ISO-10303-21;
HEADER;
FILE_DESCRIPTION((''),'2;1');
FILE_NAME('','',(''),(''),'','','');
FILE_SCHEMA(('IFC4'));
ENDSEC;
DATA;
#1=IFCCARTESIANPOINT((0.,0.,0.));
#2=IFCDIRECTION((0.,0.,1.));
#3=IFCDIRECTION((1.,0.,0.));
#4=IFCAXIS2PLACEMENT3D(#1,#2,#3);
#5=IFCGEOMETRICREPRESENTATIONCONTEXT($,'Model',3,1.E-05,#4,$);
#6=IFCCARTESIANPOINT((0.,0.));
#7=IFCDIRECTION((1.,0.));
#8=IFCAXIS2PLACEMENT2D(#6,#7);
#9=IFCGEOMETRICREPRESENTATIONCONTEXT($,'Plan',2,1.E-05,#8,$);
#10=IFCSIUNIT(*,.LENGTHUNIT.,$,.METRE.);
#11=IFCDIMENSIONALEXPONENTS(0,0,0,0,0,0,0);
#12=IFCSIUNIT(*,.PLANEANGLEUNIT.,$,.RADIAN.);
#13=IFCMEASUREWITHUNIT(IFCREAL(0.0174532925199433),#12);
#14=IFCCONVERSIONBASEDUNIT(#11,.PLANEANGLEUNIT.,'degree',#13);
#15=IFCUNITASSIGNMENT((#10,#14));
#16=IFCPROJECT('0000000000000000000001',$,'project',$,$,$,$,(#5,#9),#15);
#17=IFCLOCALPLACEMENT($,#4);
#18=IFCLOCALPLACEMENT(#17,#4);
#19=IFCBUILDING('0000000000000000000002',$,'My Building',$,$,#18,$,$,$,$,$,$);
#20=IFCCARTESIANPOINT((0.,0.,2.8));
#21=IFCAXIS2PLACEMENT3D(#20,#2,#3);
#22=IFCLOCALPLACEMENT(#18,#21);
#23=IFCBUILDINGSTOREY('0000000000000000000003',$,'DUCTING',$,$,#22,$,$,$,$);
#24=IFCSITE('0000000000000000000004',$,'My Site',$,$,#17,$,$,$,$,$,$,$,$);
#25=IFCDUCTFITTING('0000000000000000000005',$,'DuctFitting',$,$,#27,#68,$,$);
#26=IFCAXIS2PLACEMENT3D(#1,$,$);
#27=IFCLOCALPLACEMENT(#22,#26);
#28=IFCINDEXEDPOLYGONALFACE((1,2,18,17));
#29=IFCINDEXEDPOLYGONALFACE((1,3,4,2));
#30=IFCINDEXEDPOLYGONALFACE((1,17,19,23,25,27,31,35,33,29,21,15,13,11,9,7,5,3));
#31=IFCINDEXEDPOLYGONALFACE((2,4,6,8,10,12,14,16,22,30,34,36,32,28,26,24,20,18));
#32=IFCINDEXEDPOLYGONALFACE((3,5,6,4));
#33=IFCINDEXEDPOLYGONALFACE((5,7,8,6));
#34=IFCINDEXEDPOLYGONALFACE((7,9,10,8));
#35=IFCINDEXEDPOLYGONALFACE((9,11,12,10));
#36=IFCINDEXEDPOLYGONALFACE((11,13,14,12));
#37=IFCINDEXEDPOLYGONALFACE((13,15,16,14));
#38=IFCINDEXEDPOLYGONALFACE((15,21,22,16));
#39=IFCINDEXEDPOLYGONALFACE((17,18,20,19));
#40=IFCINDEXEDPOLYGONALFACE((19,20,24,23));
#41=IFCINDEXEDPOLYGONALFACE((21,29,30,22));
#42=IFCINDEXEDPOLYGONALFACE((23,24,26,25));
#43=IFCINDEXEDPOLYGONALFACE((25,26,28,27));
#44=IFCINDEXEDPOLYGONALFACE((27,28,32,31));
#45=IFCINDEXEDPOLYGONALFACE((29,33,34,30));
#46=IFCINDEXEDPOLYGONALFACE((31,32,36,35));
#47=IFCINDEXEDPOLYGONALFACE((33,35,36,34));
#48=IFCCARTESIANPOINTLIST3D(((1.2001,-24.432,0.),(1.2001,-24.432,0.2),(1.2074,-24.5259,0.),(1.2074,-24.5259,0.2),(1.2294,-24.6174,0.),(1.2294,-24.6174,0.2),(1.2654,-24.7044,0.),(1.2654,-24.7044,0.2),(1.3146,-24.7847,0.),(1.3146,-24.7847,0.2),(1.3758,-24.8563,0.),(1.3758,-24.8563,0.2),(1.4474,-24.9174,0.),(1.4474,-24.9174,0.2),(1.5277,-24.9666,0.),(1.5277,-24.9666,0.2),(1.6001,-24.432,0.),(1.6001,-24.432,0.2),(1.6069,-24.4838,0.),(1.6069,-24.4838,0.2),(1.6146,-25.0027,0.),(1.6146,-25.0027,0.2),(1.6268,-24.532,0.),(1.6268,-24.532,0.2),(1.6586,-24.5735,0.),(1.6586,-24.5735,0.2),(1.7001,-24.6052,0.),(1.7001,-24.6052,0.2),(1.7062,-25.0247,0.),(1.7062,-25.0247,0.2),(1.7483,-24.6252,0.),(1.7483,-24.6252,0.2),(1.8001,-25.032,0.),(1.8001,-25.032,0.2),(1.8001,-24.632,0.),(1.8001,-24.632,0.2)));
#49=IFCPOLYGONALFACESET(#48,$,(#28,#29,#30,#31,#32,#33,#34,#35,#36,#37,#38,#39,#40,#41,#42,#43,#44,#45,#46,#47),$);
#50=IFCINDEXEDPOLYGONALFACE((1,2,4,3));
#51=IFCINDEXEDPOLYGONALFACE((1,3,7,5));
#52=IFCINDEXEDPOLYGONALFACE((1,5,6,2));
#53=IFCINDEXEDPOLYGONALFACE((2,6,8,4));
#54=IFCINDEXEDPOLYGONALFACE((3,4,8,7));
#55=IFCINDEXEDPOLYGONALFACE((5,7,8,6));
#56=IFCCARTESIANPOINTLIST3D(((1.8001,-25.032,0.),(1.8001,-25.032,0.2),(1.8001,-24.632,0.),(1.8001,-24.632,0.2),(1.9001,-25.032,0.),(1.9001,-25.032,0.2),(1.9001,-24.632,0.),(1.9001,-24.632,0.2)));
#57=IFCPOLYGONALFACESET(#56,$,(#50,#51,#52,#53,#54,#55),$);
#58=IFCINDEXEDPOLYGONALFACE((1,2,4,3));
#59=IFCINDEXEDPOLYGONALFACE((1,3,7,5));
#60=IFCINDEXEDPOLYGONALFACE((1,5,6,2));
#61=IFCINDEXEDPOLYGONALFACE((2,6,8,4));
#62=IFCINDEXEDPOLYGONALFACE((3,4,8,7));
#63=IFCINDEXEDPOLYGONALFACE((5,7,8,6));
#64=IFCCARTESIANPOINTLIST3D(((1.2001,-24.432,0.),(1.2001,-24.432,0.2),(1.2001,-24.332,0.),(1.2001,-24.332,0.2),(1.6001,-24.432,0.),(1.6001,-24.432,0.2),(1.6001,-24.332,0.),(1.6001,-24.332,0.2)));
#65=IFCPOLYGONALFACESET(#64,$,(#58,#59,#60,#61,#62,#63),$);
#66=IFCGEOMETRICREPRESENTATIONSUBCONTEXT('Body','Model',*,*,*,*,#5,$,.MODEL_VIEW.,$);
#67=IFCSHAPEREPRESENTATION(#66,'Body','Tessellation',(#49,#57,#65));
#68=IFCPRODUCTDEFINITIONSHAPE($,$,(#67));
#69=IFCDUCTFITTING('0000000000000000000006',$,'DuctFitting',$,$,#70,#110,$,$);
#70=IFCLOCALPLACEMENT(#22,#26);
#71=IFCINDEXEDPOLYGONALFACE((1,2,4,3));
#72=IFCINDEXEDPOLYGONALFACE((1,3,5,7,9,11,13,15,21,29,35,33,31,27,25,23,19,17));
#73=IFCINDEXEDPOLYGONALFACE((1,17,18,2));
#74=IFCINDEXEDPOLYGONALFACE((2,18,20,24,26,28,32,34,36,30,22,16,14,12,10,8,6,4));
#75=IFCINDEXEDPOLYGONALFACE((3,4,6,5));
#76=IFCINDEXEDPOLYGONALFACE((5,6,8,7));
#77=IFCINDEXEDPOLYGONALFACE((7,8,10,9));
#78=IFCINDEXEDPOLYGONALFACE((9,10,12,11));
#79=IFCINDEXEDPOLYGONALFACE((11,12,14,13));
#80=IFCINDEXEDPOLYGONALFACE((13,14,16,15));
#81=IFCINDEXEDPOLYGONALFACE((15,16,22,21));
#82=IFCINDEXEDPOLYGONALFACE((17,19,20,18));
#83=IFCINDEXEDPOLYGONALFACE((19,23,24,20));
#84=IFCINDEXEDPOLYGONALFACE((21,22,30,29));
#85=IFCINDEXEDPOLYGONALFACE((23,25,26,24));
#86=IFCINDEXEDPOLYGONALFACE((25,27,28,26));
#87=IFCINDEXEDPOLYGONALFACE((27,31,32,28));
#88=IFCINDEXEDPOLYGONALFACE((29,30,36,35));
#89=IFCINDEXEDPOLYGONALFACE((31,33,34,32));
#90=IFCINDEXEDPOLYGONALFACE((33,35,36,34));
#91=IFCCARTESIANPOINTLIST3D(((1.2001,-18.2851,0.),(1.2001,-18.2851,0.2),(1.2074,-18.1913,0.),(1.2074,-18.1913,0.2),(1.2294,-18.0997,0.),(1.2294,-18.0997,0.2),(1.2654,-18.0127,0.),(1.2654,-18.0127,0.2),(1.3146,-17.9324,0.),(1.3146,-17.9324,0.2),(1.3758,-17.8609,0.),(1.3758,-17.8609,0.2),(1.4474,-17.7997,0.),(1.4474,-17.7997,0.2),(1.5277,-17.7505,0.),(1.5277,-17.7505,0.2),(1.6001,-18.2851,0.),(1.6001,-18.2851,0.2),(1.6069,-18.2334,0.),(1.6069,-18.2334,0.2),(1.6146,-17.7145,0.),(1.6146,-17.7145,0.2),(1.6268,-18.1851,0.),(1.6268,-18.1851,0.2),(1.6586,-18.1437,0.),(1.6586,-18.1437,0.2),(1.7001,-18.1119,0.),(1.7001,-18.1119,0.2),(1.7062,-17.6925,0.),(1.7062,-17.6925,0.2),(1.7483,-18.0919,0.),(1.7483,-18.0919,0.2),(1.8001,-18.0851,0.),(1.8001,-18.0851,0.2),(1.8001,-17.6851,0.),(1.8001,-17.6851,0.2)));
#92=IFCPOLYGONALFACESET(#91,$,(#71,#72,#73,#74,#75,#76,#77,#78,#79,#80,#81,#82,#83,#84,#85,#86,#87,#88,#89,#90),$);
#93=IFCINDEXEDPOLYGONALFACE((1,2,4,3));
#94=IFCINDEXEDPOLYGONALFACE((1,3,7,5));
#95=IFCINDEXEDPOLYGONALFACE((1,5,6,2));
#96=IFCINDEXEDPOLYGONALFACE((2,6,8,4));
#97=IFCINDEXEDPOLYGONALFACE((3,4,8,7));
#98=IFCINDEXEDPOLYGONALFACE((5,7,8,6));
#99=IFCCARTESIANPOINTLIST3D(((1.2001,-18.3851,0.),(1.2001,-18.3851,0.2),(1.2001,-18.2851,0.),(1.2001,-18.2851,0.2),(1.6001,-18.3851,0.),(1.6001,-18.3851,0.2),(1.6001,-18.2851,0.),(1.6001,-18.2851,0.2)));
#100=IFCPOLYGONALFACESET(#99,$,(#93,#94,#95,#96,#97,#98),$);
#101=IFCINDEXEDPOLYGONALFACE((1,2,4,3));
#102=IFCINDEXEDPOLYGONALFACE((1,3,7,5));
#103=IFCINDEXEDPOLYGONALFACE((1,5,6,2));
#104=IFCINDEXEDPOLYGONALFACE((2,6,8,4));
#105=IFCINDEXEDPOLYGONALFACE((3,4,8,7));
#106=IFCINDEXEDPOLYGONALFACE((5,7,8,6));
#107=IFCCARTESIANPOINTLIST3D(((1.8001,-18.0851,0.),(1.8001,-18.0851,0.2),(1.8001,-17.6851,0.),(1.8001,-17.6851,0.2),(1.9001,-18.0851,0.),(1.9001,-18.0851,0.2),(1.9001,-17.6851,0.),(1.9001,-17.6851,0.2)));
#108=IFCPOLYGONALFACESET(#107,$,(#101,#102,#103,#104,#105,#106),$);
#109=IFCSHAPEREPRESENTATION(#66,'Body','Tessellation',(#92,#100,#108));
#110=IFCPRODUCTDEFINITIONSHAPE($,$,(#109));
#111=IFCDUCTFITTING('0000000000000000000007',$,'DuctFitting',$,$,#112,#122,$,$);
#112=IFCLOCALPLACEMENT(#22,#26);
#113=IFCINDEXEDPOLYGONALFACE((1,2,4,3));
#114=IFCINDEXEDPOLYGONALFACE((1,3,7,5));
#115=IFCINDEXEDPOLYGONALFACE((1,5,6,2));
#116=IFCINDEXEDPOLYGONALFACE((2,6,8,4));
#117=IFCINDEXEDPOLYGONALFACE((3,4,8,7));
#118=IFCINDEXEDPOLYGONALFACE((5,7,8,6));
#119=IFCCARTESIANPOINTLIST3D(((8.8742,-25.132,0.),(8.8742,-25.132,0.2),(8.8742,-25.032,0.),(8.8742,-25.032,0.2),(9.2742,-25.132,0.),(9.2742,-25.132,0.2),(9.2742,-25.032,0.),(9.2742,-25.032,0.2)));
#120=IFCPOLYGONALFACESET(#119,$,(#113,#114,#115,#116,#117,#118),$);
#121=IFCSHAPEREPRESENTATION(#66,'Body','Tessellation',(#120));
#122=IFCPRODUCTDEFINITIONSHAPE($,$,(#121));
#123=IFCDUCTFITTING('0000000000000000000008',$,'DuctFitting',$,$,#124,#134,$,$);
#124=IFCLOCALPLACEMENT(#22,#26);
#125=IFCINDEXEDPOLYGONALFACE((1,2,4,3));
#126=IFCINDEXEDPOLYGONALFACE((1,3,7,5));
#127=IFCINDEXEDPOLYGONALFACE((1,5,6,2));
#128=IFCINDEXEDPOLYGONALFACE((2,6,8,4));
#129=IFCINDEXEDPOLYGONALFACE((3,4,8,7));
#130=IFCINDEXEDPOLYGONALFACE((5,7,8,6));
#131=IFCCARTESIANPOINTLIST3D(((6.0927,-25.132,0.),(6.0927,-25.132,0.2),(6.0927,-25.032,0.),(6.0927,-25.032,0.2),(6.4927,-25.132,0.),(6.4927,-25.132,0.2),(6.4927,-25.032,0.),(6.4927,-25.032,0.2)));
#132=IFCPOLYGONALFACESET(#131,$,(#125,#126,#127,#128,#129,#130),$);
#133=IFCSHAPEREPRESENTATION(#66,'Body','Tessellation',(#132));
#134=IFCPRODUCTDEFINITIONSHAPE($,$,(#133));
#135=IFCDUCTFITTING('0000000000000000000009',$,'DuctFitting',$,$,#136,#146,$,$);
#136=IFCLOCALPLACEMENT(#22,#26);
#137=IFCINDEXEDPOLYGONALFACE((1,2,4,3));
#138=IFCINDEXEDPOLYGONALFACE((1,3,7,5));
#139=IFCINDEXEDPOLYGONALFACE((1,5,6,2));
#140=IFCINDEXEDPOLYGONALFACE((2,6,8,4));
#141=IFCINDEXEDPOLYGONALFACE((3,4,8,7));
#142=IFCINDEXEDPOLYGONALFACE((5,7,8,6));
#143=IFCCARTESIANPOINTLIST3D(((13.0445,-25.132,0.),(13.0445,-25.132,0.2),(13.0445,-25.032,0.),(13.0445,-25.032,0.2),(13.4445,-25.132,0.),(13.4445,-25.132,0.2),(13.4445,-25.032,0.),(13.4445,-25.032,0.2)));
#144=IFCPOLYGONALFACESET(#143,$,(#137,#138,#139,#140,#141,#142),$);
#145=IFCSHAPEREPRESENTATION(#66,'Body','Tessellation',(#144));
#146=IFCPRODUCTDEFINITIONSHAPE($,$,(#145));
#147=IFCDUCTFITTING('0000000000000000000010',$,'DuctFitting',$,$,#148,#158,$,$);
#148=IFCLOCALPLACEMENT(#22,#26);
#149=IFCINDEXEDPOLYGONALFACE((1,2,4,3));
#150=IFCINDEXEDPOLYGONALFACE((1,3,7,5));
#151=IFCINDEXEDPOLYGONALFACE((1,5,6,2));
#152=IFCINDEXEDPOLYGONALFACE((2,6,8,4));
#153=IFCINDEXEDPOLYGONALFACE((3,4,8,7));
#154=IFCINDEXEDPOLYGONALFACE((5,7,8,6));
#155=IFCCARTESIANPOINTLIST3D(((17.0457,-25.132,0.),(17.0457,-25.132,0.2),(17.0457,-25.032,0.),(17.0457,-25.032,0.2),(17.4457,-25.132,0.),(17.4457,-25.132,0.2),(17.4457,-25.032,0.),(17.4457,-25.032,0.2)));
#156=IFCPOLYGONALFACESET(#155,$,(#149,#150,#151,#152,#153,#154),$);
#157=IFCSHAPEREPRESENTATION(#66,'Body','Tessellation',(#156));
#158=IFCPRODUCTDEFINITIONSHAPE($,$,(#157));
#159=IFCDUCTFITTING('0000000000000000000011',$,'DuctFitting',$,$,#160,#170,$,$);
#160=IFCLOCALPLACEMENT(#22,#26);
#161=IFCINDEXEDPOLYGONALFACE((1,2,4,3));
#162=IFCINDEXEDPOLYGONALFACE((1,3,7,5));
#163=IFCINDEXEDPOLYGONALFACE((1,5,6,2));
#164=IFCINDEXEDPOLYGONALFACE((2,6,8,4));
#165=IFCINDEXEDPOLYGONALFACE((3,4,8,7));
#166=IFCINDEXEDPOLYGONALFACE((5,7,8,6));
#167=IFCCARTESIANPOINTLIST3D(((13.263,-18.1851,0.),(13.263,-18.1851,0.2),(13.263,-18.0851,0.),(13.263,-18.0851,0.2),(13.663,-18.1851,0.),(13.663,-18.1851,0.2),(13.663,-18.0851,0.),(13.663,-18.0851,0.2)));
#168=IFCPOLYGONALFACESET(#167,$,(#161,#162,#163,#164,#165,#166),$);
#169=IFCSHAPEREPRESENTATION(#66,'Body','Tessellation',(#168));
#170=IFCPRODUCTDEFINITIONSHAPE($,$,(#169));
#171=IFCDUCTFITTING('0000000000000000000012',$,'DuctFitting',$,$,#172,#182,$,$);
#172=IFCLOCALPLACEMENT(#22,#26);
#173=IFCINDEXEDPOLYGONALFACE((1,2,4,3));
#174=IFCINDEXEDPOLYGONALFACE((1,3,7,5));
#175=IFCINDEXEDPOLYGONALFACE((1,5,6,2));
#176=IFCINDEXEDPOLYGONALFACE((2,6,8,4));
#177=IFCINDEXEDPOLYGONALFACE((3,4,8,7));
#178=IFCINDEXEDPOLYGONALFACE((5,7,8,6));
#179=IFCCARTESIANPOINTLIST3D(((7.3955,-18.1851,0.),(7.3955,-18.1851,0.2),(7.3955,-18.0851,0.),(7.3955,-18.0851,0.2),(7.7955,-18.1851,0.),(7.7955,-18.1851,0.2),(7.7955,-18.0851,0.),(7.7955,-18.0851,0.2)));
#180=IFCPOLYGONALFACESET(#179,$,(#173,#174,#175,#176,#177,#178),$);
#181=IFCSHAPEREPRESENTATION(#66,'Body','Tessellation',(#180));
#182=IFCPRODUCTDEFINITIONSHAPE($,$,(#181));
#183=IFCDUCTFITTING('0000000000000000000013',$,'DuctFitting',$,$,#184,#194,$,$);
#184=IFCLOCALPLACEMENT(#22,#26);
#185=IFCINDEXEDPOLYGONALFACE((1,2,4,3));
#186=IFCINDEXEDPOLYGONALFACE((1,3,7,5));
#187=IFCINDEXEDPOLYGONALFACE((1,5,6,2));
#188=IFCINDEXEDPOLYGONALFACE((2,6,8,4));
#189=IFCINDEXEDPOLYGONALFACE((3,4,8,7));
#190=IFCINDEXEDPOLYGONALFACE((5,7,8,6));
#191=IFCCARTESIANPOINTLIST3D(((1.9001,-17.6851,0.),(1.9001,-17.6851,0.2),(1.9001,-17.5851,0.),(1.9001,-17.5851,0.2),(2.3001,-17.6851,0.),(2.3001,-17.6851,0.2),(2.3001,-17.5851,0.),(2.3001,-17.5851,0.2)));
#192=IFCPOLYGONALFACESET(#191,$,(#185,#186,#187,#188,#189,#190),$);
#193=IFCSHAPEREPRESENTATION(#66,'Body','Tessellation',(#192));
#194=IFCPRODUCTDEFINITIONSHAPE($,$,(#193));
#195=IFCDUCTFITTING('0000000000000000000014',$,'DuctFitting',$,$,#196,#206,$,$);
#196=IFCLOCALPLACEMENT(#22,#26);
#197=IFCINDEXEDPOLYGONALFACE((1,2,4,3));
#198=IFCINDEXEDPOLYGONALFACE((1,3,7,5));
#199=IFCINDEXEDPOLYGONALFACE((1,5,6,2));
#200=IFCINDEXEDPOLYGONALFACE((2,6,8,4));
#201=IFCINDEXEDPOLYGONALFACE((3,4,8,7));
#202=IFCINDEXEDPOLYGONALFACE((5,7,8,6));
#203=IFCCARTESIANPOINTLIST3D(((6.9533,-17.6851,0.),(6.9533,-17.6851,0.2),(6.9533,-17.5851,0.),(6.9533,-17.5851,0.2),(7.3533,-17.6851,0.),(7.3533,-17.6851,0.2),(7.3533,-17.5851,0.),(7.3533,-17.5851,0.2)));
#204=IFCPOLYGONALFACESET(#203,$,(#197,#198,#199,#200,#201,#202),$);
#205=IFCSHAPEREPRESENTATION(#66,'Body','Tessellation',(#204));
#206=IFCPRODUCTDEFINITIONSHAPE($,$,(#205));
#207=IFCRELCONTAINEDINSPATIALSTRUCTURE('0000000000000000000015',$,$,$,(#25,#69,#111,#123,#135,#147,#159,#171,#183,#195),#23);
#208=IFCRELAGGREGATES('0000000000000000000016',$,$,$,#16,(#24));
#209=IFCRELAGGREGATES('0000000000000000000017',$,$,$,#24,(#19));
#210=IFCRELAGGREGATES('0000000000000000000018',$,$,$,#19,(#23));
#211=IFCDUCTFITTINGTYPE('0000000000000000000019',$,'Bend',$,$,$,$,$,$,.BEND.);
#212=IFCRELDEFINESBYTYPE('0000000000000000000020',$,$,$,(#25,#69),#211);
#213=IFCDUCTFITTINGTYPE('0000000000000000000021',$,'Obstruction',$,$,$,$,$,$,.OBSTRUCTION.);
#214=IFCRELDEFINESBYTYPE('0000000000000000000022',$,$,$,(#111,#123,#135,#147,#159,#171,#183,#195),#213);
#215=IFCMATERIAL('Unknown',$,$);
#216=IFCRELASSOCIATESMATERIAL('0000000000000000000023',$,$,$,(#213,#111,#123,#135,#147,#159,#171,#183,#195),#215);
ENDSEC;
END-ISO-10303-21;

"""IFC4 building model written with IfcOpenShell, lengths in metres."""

from ifc_helpers import new_model, entity, si_unit, converted_unit, frame, origin_with_axes, origin_2d_with_axis, place, context, subcontext, project, spatial, line, arc, indexed_curve, rectangle, outline, extrude, source, transform, mapped, material, material_profile, profile_set, profile_usage, type_object, type_shapes, element, save


model = new_model("IFC4")

# Units and contexts
model_context = context("Model", 3, precision=1e-05, world=origin_with_axes())
plan_context = context("Plan", 2, precision=1e-05, world=origin_2d_with_axis())
body_context = subcontext(model_context, "Body", "Model", "MODEL_VIEW")
ifc_project = project(units=[si_unit("LENGTHUNIT", "METRE"), converted_unit("PLANEANGLEUNIT", "degree", entity("IfcReal", 0.0174532925199433), si_unit("PLANEANGLEUNIT", "RADIAN"), dimensions=[0, 0, 0, 0, 0, 0, 0])], contexts=[model_context, plan_context])

# Site, building, storey
site_placement = place(None, origin_with_axes())
site = spatial("IfcSite", under=ifc_project, at=site_placement, Name="My Site")
building_placement = place(site_placement, origin_with_axes())
building = spatial("IfcBuilding", under=site, at=building_placement, Name="My Building")
storey_placement = place(building_placement, frame((0.0, 0.0, 2.8), z_axis=(0.0, 0.0, 1.0), x_axis=(1.0, 0.0, 0.0)))
storey = spatial("IfcBuildingStorey", under=building, at=storey_placement, Name="DUCTING")

# Shared definitions
ifc_material = material(Name="Unknown")

# Duct fittings
duct_fitting_type_1 = type_object("IfcDuctFittingType", Name="Bend", PredefinedType="BEND")
shared_shape = source(origin_with_axes(), body_context, "Body", "SweptSolid", [
    extrude(outline(indexed_curve([(0.2, 0.0), (0.2586, -0.1414), (0.4, -0.2), (0.4, -0.6), (-0.0243, -0.4243), (-0.2, 0.0)], segments=[arc(1, 2, 3), line(3, 4), arc(4, 5, 6), line(6, 1)])), frame((0.0, -0.1, -0.1), z_axis=(0.0, -1.0, 0.0), x_axis=(1.0, 0.0, 0.0)), (0.0, 0.0, -1.0), 0.2),
    extrude(rectangle(XDim=0.4, YDim=0.2), origin_with_axes(), (0.0, 0.0, -1.0), 0.1),
    extrude(rectangle(XDim=0.4, YDim=0.2), frame((0.4, 0.0, -0.5), z_axis=(1.0, 0.0, 0.0), x_axis=(0.0, 0.0, 1.0)), (0.0, 0.0, 1.0), 0.1),
])
type_shapes(duct_fitting_type_1, [shared_shape])
for number, where, z_axis, x_axis, name in (
    (1, (1.9001, -24.832, 0.1), (1.0, 0.000001, 0.000001), (-0.000001, 1.0, 0.0), "DuctFitting"),
    (2, (1.4001, -18.3851, 0.1), (0.0, -1.0, 0.0), (1.0, 0.0, 0.0), "DuctFitting"),
):
    element("IfcDuctFitting", number, at=place(storey_placement, frame(where, z_axis=z_axis, x_axis=x_axis)), inside=storey, type_object=duct_fitting_type_1, Name=name, context=body_context, shape_type="MappedRepresentation", body=[
        mapped(shared_shape, transform((0.0, 0.0, 0.0), x_axis=(1.0, 0.0, 0.0), y_axis=(0.0, 1.0, 0.0), z_axis=(0.0, 0.0, 1.0), scale=1.0)),
    ])
ifc_material_profile_1 = material_profile(ifc_material, rectangle(XDim=0.4, YDim=0.2))
ifc_profile_set_1 = profile_set([ifc_material_profile_1])
ifc_profile_usage_1 = profile_usage(ifc_profile_set_1, cardinal=5)
duct_fitting_type_2 = type_object("IfcDuctFittingType", Name="Obstruction", PredefinedType="OBSTRUCTION", material=ifc_profile_set_1)
duct_fitting_1_placement = place(storey_placement, frame((9.0742, -25.032, 0.1), z_axis=(0.0, -1.0, 0.0), x_axis=(1.0, 0.0, 0.0)))
element("IfcDuctFitting", 3, at=duct_fitting_1_placement, inside=storey, type_object=duct_fitting_type_2, material=ifc_profile_usage_1, Name="DuctFitting", context=body_context, shape_type="SweptSolid", body=[
    extrude(rectangle(XDim=0.4, YDim=0.2), origin_with_axes(), (0.0, 0.0, 1.0), 0.1),
])
ifc_profile_usage_2 = profile_usage(ifc_profile_set_1, cardinal=5)
duct_fitting_2_placement = place(storey_placement, frame((6.2927, -25.032, 0.1), z_axis=(0.0, -1.0, 0.0), x_axis=(1.0, 0.0, 0.0)))
element("IfcDuctFitting", 4, at=duct_fitting_2_placement, inside=storey, type_object=duct_fitting_type_2, material=ifc_profile_usage_2, Name="DuctFitting", context=body_context, shape_type="SweptSolid", body=[
    extrude(rectangle(XDim=0.4, YDim=0.2), origin_with_axes(), (0.0, 0.0, 1.0), 0.1),
])
ifc_profile_usage_3 = profile_usage(ifc_profile_set_1, cardinal=5)
duct_fitting_3_placement = place(storey_placement, frame((13.2445, -25.032, 0.1), z_axis=(0.0, -1.0, 0.0), x_axis=(1.0, 0.0, 0.0)))
element("IfcDuctFitting", 5, at=duct_fitting_3_placement, inside=storey, type_object=duct_fitting_type_2, material=ifc_profile_usage_3, Name="DuctFitting", context=body_context, shape_type="SweptSolid", body=[
    extrude(rectangle(XDim=0.4, YDim=0.2), origin_with_axes(), (0.0, 0.0, 1.0), 0.1),
])
ifc_profile_usage_4 = profile_usage(ifc_profile_set_1, cardinal=5)
duct_fitting_4_placement = place(storey_placement, frame((17.2457, -25.032, 0.1), z_axis=(0.0, -1.0, 0.0), x_axis=(1.0, 0.0, 0.0)))
element("IfcDuctFitting", 6, at=duct_fitting_4_placement, inside=storey, type_object=duct_fitting_type_2, material=ifc_profile_usage_4, Name="DuctFitting", context=body_context, shape_type="SweptSolid", body=[
    extrude(rectangle(XDim=0.4, YDim=0.2), origin_with_axes(), (0.0, 0.0, 1.0), 0.1),
])
ifc_profile_usage_5 = profile_usage(ifc_profile_set_1, cardinal=5)
duct_fitting_5_placement = place(storey_placement, frame((13.463, -18.0851, 0.1), z_axis=(0.0, -1.0, 0.0), x_axis=(1.0, 0.0, 0.0)))
element("IfcDuctFitting", 7, at=duct_fitting_5_placement, inside=storey, type_object=duct_fitting_type_2, material=ifc_profile_usage_5, Name="DuctFitting", context=body_context, shape_type="SweptSolid", body=[
    extrude(rectangle(XDim=0.4, YDim=0.2), origin_with_axes(), (0.0, 0.0, 1.0), 0.1),
])
ifc_profile_usage_6 = profile_usage(ifc_profile_set_1, cardinal=5)
duct_fitting_6_placement = place(storey_placement, frame((7.5955, -18.0851, 0.1), z_axis=(0.0, -1.0, 0.0), x_axis=(1.0, 0.0, 0.0)))
element("IfcDuctFitting", 8, at=duct_fitting_6_placement, inside=storey, type_object=duct_fitting_type_2, material=ifc_profile_usage_6, Name="DuctFitting", context=body_context, shape_type="SweptSolid", body=[
    extrude(rectangle(XDim=0.4, YDim=0.2), origin_with_axes(), (0.0, 0.0, 1.0), 0.1),
])
ifc_profile_usage_7 = profile_usage(ifc_profile_set_1, cardinal=5)
duct_fitting_7_placement = place(storey_placement, frame((2.1001, -17.6851, 0.1), z_axis=(0.0, 1.0, 0.0), x_axis=(-1.0, 0.0, 0.0)))
element("IfcDuctFitting", 9, at=duct_fitting_7_placement, inside=storey, type_object=duct_fitting_type_2, material=ifc_profile_usage_7, Name="DuctFitting", context=body_context, shape_type="SweptSolid", body=[
    extrude(rectangle(XDim=0.4, YDim=0.2), origin_with_axes(), (0.0, 0.0, 1.0), 0.1),
])
ifc_profile_usage_8 = profile_usage(ifc_profile_set_1, cardinal=5)
duct_fitting_8_placement = place(storey_placement, frame((7.1533, -17.6851, 0.1), z_axis=(0.0, 1.0, 0.0), x_axis=(-1.0, 0.0, 0.0)))
element("IfcDuctFitting", 10, at=duct_fitting_8_placement, inside=storey, type_object=duct_fitting_type_2, material=ifc_profile_usage_8, Name="DuctFitting", context=body_context, shape_type="SweptSolid", body=[
    extrude(rectangle(XDim=0.4, YDim=0.2), origin_with_axes(), (0.0, 0.0, 1.0), 0.1),
])

save(model, "model.ifc")
